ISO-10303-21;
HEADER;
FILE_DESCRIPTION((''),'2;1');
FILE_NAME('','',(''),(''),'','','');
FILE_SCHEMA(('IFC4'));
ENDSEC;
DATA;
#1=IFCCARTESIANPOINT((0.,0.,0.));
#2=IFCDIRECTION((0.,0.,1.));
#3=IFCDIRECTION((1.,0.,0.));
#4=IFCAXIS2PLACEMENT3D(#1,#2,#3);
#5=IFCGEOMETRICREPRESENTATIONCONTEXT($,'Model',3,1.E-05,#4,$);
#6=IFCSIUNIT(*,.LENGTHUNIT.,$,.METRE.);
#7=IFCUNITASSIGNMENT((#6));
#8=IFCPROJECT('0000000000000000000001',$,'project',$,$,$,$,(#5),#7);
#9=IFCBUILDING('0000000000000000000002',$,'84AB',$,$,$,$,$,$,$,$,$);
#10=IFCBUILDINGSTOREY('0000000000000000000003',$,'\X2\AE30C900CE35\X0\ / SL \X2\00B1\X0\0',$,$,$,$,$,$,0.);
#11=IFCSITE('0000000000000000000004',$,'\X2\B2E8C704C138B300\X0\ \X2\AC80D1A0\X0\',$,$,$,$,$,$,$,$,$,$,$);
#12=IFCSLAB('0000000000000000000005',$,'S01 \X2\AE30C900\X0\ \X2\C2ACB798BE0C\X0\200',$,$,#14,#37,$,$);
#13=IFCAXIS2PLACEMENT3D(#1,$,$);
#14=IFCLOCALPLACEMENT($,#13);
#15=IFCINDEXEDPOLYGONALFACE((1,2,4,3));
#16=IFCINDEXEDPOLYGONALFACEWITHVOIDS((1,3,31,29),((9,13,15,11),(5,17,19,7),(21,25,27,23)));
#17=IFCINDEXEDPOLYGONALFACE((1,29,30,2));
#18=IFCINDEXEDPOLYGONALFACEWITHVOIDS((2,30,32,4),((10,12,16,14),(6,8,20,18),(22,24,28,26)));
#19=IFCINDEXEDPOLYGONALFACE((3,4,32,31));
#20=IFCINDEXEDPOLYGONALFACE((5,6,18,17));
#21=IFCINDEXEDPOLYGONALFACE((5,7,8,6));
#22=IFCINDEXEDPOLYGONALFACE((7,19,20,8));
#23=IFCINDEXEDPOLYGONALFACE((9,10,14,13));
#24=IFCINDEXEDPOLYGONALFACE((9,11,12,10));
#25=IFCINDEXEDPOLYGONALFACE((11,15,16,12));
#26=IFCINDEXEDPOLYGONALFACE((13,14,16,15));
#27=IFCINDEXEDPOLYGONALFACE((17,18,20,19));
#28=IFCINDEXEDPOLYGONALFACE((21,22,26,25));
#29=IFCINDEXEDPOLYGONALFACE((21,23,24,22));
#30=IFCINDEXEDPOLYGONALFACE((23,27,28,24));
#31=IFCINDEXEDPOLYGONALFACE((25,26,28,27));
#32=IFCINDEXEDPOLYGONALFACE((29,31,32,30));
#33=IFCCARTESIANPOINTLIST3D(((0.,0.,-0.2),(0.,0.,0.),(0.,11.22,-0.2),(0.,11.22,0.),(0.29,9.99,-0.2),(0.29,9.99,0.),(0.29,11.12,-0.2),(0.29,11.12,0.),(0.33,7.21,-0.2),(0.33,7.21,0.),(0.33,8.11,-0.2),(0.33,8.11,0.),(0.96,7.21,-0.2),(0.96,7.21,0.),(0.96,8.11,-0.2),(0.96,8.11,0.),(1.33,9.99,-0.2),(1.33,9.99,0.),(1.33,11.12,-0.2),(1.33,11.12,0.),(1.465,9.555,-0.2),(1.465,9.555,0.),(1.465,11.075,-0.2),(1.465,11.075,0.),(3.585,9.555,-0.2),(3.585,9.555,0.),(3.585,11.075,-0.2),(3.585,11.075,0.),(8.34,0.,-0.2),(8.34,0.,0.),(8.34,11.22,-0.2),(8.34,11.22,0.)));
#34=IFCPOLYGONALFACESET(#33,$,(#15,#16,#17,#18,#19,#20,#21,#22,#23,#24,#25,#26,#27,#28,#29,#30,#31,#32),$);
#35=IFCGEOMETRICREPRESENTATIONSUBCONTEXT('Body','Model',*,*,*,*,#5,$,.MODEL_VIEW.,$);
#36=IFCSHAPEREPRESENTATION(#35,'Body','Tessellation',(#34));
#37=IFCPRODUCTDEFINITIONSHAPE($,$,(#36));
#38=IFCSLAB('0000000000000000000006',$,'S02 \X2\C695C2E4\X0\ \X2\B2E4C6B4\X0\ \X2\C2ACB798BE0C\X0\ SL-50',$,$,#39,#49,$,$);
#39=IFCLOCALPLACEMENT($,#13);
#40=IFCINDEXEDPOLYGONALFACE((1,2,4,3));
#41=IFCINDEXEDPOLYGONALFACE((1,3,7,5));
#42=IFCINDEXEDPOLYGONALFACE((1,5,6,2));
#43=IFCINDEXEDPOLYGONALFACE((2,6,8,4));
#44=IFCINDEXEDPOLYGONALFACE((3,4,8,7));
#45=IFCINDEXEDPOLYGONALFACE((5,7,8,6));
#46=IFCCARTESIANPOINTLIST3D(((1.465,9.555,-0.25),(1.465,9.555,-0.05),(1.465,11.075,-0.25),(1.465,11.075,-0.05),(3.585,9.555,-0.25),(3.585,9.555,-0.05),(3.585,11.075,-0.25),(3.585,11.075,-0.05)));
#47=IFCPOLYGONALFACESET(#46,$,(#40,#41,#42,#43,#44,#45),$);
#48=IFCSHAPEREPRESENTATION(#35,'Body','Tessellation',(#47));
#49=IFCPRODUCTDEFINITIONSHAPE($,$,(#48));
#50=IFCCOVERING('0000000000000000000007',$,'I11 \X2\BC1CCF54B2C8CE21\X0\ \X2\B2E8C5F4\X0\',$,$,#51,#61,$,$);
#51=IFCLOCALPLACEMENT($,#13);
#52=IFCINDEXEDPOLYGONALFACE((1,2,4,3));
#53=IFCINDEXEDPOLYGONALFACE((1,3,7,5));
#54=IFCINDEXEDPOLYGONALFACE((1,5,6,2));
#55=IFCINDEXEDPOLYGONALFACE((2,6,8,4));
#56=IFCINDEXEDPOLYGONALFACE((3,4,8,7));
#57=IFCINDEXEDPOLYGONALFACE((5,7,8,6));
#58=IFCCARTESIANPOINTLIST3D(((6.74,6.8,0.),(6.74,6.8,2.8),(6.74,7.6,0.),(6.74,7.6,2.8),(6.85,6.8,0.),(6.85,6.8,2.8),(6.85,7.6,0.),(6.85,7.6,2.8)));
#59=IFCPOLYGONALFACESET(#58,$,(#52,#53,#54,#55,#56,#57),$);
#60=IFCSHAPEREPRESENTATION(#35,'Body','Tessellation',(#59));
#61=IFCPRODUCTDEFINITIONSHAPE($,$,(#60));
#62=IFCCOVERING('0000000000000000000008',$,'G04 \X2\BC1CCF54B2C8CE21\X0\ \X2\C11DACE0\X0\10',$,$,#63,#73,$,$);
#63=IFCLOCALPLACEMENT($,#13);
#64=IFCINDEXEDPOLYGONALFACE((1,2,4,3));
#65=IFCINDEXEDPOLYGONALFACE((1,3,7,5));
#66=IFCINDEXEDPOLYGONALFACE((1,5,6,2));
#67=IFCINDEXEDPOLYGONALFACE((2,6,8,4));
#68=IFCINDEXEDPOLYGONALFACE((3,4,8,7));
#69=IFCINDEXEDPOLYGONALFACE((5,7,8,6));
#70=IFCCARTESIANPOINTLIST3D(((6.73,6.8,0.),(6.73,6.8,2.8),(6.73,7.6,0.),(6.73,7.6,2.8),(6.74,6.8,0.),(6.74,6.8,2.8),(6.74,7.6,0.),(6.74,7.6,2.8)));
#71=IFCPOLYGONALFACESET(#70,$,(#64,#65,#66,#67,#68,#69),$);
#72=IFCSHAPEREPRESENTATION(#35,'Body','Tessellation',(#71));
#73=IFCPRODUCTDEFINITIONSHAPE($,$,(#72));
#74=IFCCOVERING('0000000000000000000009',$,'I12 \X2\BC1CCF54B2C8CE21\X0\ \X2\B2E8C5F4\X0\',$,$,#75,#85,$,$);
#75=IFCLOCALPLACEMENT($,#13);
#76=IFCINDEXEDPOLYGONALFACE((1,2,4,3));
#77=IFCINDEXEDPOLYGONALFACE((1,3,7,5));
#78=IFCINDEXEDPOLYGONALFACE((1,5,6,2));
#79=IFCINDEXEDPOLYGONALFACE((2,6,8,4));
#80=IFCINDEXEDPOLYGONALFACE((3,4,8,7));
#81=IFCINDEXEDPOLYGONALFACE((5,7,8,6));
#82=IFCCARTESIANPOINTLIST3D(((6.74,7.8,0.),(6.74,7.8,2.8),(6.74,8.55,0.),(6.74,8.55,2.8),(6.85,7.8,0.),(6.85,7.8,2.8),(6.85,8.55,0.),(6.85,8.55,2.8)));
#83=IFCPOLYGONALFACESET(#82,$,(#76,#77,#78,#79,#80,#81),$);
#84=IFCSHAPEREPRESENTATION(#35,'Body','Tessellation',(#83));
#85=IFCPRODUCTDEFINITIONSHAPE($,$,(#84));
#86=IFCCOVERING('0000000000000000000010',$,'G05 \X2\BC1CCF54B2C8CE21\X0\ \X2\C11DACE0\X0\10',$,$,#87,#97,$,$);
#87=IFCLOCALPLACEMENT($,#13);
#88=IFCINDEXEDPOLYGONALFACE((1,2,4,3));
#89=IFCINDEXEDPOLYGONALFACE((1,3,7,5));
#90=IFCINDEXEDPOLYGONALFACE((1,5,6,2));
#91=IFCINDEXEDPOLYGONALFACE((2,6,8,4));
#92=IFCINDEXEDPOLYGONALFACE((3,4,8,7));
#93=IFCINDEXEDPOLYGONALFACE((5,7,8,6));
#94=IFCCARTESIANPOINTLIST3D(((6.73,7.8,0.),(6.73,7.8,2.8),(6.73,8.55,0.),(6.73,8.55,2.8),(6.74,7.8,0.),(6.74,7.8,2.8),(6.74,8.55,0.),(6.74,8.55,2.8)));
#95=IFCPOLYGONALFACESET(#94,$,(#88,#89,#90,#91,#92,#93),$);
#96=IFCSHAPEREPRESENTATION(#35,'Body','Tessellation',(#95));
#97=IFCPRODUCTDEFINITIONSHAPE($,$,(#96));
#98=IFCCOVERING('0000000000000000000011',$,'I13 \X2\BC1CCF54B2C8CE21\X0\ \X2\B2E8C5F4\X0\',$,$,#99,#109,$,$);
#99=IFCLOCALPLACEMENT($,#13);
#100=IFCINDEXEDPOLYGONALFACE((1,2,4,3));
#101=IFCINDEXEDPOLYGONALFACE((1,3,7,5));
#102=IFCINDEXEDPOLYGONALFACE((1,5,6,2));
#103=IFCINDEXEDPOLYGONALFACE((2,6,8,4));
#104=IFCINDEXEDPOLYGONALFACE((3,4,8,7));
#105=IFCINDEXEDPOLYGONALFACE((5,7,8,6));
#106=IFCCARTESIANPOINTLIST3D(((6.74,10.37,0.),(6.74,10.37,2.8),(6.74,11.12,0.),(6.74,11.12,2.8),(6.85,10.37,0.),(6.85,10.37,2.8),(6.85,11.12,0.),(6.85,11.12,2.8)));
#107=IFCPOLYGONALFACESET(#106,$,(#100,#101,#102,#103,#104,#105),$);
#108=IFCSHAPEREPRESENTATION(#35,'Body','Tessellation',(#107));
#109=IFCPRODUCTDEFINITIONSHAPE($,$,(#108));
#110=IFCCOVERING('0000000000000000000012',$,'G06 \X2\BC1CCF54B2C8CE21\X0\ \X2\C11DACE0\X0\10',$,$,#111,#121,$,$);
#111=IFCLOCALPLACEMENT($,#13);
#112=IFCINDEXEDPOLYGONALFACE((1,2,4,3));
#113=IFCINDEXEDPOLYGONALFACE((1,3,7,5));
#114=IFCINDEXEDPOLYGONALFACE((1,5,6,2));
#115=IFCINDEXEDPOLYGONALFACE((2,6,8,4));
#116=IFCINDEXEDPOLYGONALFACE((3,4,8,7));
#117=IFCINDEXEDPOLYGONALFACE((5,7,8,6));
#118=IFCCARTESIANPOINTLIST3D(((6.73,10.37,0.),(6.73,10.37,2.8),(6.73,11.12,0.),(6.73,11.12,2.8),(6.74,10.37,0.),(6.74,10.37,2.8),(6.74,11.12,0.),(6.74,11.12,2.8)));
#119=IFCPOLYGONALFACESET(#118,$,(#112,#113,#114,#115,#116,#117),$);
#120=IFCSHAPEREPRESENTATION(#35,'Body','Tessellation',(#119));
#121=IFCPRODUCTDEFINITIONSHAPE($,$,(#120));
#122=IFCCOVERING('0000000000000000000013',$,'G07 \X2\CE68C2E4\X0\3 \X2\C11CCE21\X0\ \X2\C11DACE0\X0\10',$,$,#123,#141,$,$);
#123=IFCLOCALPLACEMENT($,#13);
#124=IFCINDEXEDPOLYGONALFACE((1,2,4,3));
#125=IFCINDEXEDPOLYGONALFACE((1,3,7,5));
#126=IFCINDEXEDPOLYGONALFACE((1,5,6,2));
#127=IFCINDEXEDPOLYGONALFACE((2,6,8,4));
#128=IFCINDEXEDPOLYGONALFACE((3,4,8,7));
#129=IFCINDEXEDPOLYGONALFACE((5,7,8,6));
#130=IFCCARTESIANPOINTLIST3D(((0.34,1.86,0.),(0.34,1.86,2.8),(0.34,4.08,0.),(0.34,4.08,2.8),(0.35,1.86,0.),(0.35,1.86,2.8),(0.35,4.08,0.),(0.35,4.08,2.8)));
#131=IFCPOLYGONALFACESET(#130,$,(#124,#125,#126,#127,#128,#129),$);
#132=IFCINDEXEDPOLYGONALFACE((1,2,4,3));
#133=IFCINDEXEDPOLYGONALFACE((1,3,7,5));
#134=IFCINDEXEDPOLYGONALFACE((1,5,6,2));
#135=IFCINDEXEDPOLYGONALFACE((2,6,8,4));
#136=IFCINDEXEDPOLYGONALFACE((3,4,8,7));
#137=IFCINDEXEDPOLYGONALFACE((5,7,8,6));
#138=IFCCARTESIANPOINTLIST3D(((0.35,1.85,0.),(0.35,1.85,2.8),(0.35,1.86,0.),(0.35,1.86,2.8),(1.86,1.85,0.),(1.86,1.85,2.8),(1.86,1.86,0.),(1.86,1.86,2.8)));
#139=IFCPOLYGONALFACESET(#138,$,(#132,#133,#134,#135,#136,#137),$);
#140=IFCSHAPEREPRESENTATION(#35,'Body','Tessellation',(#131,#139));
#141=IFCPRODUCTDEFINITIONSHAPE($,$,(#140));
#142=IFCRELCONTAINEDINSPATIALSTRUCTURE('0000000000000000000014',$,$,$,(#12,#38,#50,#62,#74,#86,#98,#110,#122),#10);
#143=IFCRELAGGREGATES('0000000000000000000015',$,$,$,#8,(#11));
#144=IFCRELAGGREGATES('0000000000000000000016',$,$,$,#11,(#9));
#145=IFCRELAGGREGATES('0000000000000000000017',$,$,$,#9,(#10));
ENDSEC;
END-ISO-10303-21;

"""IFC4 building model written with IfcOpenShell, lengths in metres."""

from ifc_helpers import new_model, si_unit, frame, origin, origin_with_axes, place, context, subcontext, project, spatial, polyline, outline, extrude, element, save


model = new_model("IFC4")

# Units and contexts
model_context = context("Model", 3, precision=1e-05, world=origin_with_axes())
body_context = subcontext(model_context, "Body", "Model", "MODEL_VIEW")
ifc_project = project(units=[si_unit("LENGTHUNIT", "METRE")], contexts=[model_context])

# Site, building, storey
site = spatial("IfcSite", under=ifc_project, Name="단위세대 검토")
building = spatial("IfcBuilding", under=site, Name="84AB")
storey = spatial("IfcBuildingStorey", under=building, Name="기준층 / SL ±0", Elevation=0.0)

# Slabs
slab_1_placement = place(None, origin_with_axes())
element("IfcSlab", 1, at=slab_1_placement, inside=storey, Name="S01 기준 슬래브200", context=body_context, shape_type="SweptSolid", body=[
    extrude(outline(polyline([(0.0, 0.0), (0.0, 11.22), (8.34, 11.22), (8.34, 0.0), (0.0, 0.0)]), holes=[polyline([(0.33, 8.11), (0.33, 7.21), (0.96, 7.21), (0.96, 8.11), (0.33, 8.11)]), polyline([(3.585, 9.555), (3.585, 11.075), (1.465, 11.075), (1.465, 9.555), (3.585, 9.555)]), polyline([(1.33, 11.12), (0.29, 11.12), (0.29, 9.99), (1.33, 9.99), (1.33, 11.12)])]), frame((0.0, 0.0, -0.2)), (0.0, 0.0, 1.0), 0.2),
])
slab_2_placement = place(None, origin_with_axes())
element("IfcSlab", 2, at=slab_2_placement, inside=storey, Name="S02 욕실 다운 슬래브 SL-50", context=body_context, shape_type="SweptSolid", body=[
    extrude(outline(polyline([(3.585, 11.075), (1.465, 11.075), (1.465, 9.555), (3.585, 9.555), (3.585, 11.075)])), frame((0.0, 0.0, -0.25)), (0.0, 0.0, 1.0), 0.2),
])

# Coverings
covering_1_placement = place(None, origin_with_axes())
element("IfcCovering", 3, at=covering_1_placement, inside=storey, Name="I11 발코니측 단열", context=body_context, shape_type="SweptSolid", body=[
    extrude(outline(polyline([(6.85, 6.8), (6.85, 7.6), (6.74, 7.6), (6.74, 6.8), (6.85, 6.8)])), origin(), (0.0, 0.0, 1.0), 2.8),
])
covering_2_placement = place(None, origin_with_axes())
element("IfcCovering", 4, at=covering_2_placement, inside=storey, Name="G04 발코니측 석고10", context=body_context, shape_type="SweptSolid", body=[
    extrude(outline(polyline([(6.74, 6.8), (6.74, 7.6), (6.73, 7.6), (6.73, 6.8), (6.74, 6.8)])), origin(), (0.0, 0.0, 1.0), 2.8),
])
covering_3_placement = place(None, origin_with_axes())
element("IfcCovering", 5, at=covering_3_placement, inside=storey, Name="I12 발코니측 단열", context=body_context, shape_type="SweptSolid", body=[
    extrude(outline(polyline([(6.85, 7.8), (6.85, 8.55), (6.74, 8.55), (6.74, 7.8), (6.85, 7.8)])), origin(), (0.0, 0.0, 1.0), 2.8),
])
covering_4_placement = place(None, origin_with_axes())
element("IfcCovering", 6, at=covering_4_placement, inside=storey, Name="G05 발코니측 석고10", context=body_context, shape_type="SweptSolid", body=[
    extrude(outline(polyline([(6.74, 7.8), (6.74, 8.55), (6.73, 8.55), (6.73, 7.8), (6.74, 7.8)])), origin(), (0.0, 0.0, 1.0), 2.8),
])
covering_5_placement = place(None, origin_with_axes())
element("IfcCovering", 7, at=covering_5_placement, inside=storey, Name="I13 발코니측 단열", context=body_context, shape_type="SweptSolid", body=[
    extrude(outline(polyline([(6.85, 10.37), (6.85, 11.12), (6.74, 11.12), (6.74, 10.37), (6.85, 10.37)])), origin(), (0.0, 0.0, 1.0), 2.8),
])
covering_6_placement = place(None, origin_with_axes())
element("IfcCovering", 8, at=covering_6_placement, inside=storey, Name="G06 발코니측 석고10", context=body_context, shape_type="SweptSolid", body=[
    extrude(outline(polyline([(6.74, 10.37), (6.74, 11.12), (6.73, 11.12), (6.73, 10.37), (6.74, 10.37)])), origin(), (0.0, 0.0, 1.0), 2.8),
])
covering_7_placement = place(None, origin_with_axes())
element("IfcCovering", 9, at=covering_7_placement, inside=storey, Name="G07 침실3 서측 석고10", context=body_context, shape_type="SweptSolid", body=[
    extrude(outline(polyline([(0.35, 1.86), (0.35, 4.08), (0.34, 4.08), (0.34, 1.86), (0.35, 1.86)])), origin(), (0.0, 0.0, 1.0), 2.8),
    extrude(outline(polyline([(1.86, 1.85), (1.86, 1.86), (0.35, 1.86), (0.35, 1.85), (1.86, 1.85)])), origin(), (0.0, 0.0, 1.0), 2.8),
])

save(model, "model.ifc")
